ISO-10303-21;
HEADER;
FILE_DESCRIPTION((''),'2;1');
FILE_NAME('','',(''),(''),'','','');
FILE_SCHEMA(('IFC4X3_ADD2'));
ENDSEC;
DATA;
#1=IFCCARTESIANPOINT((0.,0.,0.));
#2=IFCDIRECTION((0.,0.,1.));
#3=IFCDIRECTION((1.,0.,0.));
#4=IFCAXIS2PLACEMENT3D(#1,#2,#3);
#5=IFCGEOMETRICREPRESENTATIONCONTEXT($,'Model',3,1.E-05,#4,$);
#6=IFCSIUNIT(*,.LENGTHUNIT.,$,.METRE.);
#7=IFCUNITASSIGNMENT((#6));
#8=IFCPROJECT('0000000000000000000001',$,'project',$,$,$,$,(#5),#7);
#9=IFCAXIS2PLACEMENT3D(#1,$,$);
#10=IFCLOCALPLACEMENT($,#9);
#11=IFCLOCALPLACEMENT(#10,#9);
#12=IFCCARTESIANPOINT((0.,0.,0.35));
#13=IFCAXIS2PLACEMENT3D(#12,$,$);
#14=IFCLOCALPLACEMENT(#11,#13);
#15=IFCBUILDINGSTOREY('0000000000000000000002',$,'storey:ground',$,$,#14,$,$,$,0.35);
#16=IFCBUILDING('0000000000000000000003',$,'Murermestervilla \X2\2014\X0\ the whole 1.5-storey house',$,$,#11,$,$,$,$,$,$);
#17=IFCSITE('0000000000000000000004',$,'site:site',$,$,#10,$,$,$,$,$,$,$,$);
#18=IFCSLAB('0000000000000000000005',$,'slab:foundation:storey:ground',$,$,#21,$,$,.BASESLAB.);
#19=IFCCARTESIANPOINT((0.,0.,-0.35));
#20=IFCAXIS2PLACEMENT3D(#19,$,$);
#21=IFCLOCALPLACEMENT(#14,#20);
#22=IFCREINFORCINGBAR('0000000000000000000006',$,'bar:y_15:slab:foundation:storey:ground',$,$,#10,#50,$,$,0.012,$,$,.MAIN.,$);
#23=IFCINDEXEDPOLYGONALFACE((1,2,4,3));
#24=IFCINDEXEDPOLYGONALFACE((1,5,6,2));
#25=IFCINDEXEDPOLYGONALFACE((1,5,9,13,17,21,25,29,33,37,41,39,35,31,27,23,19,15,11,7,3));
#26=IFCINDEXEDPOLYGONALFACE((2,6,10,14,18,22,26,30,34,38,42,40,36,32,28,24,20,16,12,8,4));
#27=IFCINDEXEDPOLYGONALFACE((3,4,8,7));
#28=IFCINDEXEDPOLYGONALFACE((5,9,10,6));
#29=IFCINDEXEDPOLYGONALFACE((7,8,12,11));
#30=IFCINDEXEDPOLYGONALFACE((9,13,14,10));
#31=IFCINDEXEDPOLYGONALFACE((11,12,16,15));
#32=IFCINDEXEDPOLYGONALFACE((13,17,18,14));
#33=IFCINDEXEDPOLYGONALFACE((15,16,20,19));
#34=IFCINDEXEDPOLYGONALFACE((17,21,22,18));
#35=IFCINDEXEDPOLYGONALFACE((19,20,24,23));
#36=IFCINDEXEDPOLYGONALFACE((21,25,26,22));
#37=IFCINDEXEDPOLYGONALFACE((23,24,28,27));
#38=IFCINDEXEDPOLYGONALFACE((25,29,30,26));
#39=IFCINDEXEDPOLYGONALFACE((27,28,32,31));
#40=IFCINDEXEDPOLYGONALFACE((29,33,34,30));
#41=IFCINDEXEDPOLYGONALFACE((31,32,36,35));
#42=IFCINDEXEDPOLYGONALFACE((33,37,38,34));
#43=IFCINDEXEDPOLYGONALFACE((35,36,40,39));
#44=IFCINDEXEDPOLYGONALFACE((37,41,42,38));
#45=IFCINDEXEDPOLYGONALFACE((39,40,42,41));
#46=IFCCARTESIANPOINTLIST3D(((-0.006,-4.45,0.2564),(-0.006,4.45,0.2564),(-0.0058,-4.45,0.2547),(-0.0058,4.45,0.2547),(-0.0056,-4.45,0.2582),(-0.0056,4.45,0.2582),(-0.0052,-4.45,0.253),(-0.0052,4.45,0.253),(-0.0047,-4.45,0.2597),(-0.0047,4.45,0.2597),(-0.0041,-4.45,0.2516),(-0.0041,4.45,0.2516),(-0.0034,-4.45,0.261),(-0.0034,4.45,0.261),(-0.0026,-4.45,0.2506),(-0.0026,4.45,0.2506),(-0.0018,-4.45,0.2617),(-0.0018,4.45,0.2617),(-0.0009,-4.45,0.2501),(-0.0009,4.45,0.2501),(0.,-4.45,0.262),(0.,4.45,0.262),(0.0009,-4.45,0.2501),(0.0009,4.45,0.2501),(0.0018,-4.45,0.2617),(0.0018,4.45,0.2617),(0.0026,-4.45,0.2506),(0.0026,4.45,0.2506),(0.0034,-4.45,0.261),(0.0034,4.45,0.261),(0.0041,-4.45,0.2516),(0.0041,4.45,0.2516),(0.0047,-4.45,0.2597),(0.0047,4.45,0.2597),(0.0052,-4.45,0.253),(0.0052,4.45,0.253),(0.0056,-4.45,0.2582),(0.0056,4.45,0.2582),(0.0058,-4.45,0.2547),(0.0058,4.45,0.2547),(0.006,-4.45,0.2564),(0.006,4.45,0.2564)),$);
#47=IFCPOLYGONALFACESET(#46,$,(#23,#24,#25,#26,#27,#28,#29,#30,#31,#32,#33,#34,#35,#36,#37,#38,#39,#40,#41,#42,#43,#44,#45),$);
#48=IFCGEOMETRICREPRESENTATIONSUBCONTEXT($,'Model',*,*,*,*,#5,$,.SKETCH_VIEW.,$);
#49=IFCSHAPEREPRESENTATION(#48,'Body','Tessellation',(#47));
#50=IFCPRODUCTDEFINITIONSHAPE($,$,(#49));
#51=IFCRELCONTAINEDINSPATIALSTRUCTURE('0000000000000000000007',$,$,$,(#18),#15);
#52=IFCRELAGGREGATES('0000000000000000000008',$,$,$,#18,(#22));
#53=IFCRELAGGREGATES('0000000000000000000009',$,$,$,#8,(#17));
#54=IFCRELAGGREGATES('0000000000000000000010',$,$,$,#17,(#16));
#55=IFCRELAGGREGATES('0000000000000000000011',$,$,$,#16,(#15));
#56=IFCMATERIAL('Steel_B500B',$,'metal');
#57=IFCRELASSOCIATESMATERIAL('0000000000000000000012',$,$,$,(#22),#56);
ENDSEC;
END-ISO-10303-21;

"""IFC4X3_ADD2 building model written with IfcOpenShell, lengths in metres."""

from ifc_helpers import new_model, entity, si_unit, frame, origin, origin_with_axes, place, context, subcontext, project, spatial, material, element, aggregate, save


model = new_model("IFC4X3_ADD2")

# Units and contexts
model_context = context("Model", 3, precision=1e-05, world=origin_with_axes())
sub_context = subcontext(model_context, None, "Model", "SKETCH_VIEW")
ifc_project = project(units=[si_unit("LENGTHUNIT", "METRE")], contexts=[model_context])

# Site, building, storey
placement = place(None, origin())
site = spatial("IfcSite", under=ifc_project, at=placement, Name="site:site")
building_placement = place(placement, origin())
building = spatial("IfcBuilding", under=site, at=building_placement, Name="Murermestervilla — the whole 1.5-storey house")
storey_placement = place(building_placement, frame((0.0, 0.0, 0.35)))
storey = spatial("IfcBuildingStorey", under=building, at=storey_placement, Name="storey:ground", Elevation=0.35)

# Slab, reinforcing bar
slab_placement = place(storey_placement, frame((0.0, 0.0, -0.35)))
slab = element("IfcSlab", 1, at=slab_placement, inside=storey, Name="slab:foundation:storey:ground", PredefinedType="BASESLAB")
ifc_material = material(Name="Steel_B500B", Category="metal")
reinforcing_bar_1 = element("IfcReinforcingBar", 2, at=placement, material=ifc_material, Name="bar:y_15:slab:foundation:storey:ground", NominalDiameter=0.012, PredefinedType="MAIN", context=sub_context, shape_type="AdvancedSweptSolid", body=[
    entity("IfcSweptDiskSolid", entity("IfcPolyline", [entity("IfcCartesianPoint", [0.0, -4.45, 0.256]), entity("IfcCartesianPoint", [0.0, 4.45, 0.256])]), 0.006),
])
aggregate(slab, [reinforcing_bar_1])

save(model, "model.ifc")
